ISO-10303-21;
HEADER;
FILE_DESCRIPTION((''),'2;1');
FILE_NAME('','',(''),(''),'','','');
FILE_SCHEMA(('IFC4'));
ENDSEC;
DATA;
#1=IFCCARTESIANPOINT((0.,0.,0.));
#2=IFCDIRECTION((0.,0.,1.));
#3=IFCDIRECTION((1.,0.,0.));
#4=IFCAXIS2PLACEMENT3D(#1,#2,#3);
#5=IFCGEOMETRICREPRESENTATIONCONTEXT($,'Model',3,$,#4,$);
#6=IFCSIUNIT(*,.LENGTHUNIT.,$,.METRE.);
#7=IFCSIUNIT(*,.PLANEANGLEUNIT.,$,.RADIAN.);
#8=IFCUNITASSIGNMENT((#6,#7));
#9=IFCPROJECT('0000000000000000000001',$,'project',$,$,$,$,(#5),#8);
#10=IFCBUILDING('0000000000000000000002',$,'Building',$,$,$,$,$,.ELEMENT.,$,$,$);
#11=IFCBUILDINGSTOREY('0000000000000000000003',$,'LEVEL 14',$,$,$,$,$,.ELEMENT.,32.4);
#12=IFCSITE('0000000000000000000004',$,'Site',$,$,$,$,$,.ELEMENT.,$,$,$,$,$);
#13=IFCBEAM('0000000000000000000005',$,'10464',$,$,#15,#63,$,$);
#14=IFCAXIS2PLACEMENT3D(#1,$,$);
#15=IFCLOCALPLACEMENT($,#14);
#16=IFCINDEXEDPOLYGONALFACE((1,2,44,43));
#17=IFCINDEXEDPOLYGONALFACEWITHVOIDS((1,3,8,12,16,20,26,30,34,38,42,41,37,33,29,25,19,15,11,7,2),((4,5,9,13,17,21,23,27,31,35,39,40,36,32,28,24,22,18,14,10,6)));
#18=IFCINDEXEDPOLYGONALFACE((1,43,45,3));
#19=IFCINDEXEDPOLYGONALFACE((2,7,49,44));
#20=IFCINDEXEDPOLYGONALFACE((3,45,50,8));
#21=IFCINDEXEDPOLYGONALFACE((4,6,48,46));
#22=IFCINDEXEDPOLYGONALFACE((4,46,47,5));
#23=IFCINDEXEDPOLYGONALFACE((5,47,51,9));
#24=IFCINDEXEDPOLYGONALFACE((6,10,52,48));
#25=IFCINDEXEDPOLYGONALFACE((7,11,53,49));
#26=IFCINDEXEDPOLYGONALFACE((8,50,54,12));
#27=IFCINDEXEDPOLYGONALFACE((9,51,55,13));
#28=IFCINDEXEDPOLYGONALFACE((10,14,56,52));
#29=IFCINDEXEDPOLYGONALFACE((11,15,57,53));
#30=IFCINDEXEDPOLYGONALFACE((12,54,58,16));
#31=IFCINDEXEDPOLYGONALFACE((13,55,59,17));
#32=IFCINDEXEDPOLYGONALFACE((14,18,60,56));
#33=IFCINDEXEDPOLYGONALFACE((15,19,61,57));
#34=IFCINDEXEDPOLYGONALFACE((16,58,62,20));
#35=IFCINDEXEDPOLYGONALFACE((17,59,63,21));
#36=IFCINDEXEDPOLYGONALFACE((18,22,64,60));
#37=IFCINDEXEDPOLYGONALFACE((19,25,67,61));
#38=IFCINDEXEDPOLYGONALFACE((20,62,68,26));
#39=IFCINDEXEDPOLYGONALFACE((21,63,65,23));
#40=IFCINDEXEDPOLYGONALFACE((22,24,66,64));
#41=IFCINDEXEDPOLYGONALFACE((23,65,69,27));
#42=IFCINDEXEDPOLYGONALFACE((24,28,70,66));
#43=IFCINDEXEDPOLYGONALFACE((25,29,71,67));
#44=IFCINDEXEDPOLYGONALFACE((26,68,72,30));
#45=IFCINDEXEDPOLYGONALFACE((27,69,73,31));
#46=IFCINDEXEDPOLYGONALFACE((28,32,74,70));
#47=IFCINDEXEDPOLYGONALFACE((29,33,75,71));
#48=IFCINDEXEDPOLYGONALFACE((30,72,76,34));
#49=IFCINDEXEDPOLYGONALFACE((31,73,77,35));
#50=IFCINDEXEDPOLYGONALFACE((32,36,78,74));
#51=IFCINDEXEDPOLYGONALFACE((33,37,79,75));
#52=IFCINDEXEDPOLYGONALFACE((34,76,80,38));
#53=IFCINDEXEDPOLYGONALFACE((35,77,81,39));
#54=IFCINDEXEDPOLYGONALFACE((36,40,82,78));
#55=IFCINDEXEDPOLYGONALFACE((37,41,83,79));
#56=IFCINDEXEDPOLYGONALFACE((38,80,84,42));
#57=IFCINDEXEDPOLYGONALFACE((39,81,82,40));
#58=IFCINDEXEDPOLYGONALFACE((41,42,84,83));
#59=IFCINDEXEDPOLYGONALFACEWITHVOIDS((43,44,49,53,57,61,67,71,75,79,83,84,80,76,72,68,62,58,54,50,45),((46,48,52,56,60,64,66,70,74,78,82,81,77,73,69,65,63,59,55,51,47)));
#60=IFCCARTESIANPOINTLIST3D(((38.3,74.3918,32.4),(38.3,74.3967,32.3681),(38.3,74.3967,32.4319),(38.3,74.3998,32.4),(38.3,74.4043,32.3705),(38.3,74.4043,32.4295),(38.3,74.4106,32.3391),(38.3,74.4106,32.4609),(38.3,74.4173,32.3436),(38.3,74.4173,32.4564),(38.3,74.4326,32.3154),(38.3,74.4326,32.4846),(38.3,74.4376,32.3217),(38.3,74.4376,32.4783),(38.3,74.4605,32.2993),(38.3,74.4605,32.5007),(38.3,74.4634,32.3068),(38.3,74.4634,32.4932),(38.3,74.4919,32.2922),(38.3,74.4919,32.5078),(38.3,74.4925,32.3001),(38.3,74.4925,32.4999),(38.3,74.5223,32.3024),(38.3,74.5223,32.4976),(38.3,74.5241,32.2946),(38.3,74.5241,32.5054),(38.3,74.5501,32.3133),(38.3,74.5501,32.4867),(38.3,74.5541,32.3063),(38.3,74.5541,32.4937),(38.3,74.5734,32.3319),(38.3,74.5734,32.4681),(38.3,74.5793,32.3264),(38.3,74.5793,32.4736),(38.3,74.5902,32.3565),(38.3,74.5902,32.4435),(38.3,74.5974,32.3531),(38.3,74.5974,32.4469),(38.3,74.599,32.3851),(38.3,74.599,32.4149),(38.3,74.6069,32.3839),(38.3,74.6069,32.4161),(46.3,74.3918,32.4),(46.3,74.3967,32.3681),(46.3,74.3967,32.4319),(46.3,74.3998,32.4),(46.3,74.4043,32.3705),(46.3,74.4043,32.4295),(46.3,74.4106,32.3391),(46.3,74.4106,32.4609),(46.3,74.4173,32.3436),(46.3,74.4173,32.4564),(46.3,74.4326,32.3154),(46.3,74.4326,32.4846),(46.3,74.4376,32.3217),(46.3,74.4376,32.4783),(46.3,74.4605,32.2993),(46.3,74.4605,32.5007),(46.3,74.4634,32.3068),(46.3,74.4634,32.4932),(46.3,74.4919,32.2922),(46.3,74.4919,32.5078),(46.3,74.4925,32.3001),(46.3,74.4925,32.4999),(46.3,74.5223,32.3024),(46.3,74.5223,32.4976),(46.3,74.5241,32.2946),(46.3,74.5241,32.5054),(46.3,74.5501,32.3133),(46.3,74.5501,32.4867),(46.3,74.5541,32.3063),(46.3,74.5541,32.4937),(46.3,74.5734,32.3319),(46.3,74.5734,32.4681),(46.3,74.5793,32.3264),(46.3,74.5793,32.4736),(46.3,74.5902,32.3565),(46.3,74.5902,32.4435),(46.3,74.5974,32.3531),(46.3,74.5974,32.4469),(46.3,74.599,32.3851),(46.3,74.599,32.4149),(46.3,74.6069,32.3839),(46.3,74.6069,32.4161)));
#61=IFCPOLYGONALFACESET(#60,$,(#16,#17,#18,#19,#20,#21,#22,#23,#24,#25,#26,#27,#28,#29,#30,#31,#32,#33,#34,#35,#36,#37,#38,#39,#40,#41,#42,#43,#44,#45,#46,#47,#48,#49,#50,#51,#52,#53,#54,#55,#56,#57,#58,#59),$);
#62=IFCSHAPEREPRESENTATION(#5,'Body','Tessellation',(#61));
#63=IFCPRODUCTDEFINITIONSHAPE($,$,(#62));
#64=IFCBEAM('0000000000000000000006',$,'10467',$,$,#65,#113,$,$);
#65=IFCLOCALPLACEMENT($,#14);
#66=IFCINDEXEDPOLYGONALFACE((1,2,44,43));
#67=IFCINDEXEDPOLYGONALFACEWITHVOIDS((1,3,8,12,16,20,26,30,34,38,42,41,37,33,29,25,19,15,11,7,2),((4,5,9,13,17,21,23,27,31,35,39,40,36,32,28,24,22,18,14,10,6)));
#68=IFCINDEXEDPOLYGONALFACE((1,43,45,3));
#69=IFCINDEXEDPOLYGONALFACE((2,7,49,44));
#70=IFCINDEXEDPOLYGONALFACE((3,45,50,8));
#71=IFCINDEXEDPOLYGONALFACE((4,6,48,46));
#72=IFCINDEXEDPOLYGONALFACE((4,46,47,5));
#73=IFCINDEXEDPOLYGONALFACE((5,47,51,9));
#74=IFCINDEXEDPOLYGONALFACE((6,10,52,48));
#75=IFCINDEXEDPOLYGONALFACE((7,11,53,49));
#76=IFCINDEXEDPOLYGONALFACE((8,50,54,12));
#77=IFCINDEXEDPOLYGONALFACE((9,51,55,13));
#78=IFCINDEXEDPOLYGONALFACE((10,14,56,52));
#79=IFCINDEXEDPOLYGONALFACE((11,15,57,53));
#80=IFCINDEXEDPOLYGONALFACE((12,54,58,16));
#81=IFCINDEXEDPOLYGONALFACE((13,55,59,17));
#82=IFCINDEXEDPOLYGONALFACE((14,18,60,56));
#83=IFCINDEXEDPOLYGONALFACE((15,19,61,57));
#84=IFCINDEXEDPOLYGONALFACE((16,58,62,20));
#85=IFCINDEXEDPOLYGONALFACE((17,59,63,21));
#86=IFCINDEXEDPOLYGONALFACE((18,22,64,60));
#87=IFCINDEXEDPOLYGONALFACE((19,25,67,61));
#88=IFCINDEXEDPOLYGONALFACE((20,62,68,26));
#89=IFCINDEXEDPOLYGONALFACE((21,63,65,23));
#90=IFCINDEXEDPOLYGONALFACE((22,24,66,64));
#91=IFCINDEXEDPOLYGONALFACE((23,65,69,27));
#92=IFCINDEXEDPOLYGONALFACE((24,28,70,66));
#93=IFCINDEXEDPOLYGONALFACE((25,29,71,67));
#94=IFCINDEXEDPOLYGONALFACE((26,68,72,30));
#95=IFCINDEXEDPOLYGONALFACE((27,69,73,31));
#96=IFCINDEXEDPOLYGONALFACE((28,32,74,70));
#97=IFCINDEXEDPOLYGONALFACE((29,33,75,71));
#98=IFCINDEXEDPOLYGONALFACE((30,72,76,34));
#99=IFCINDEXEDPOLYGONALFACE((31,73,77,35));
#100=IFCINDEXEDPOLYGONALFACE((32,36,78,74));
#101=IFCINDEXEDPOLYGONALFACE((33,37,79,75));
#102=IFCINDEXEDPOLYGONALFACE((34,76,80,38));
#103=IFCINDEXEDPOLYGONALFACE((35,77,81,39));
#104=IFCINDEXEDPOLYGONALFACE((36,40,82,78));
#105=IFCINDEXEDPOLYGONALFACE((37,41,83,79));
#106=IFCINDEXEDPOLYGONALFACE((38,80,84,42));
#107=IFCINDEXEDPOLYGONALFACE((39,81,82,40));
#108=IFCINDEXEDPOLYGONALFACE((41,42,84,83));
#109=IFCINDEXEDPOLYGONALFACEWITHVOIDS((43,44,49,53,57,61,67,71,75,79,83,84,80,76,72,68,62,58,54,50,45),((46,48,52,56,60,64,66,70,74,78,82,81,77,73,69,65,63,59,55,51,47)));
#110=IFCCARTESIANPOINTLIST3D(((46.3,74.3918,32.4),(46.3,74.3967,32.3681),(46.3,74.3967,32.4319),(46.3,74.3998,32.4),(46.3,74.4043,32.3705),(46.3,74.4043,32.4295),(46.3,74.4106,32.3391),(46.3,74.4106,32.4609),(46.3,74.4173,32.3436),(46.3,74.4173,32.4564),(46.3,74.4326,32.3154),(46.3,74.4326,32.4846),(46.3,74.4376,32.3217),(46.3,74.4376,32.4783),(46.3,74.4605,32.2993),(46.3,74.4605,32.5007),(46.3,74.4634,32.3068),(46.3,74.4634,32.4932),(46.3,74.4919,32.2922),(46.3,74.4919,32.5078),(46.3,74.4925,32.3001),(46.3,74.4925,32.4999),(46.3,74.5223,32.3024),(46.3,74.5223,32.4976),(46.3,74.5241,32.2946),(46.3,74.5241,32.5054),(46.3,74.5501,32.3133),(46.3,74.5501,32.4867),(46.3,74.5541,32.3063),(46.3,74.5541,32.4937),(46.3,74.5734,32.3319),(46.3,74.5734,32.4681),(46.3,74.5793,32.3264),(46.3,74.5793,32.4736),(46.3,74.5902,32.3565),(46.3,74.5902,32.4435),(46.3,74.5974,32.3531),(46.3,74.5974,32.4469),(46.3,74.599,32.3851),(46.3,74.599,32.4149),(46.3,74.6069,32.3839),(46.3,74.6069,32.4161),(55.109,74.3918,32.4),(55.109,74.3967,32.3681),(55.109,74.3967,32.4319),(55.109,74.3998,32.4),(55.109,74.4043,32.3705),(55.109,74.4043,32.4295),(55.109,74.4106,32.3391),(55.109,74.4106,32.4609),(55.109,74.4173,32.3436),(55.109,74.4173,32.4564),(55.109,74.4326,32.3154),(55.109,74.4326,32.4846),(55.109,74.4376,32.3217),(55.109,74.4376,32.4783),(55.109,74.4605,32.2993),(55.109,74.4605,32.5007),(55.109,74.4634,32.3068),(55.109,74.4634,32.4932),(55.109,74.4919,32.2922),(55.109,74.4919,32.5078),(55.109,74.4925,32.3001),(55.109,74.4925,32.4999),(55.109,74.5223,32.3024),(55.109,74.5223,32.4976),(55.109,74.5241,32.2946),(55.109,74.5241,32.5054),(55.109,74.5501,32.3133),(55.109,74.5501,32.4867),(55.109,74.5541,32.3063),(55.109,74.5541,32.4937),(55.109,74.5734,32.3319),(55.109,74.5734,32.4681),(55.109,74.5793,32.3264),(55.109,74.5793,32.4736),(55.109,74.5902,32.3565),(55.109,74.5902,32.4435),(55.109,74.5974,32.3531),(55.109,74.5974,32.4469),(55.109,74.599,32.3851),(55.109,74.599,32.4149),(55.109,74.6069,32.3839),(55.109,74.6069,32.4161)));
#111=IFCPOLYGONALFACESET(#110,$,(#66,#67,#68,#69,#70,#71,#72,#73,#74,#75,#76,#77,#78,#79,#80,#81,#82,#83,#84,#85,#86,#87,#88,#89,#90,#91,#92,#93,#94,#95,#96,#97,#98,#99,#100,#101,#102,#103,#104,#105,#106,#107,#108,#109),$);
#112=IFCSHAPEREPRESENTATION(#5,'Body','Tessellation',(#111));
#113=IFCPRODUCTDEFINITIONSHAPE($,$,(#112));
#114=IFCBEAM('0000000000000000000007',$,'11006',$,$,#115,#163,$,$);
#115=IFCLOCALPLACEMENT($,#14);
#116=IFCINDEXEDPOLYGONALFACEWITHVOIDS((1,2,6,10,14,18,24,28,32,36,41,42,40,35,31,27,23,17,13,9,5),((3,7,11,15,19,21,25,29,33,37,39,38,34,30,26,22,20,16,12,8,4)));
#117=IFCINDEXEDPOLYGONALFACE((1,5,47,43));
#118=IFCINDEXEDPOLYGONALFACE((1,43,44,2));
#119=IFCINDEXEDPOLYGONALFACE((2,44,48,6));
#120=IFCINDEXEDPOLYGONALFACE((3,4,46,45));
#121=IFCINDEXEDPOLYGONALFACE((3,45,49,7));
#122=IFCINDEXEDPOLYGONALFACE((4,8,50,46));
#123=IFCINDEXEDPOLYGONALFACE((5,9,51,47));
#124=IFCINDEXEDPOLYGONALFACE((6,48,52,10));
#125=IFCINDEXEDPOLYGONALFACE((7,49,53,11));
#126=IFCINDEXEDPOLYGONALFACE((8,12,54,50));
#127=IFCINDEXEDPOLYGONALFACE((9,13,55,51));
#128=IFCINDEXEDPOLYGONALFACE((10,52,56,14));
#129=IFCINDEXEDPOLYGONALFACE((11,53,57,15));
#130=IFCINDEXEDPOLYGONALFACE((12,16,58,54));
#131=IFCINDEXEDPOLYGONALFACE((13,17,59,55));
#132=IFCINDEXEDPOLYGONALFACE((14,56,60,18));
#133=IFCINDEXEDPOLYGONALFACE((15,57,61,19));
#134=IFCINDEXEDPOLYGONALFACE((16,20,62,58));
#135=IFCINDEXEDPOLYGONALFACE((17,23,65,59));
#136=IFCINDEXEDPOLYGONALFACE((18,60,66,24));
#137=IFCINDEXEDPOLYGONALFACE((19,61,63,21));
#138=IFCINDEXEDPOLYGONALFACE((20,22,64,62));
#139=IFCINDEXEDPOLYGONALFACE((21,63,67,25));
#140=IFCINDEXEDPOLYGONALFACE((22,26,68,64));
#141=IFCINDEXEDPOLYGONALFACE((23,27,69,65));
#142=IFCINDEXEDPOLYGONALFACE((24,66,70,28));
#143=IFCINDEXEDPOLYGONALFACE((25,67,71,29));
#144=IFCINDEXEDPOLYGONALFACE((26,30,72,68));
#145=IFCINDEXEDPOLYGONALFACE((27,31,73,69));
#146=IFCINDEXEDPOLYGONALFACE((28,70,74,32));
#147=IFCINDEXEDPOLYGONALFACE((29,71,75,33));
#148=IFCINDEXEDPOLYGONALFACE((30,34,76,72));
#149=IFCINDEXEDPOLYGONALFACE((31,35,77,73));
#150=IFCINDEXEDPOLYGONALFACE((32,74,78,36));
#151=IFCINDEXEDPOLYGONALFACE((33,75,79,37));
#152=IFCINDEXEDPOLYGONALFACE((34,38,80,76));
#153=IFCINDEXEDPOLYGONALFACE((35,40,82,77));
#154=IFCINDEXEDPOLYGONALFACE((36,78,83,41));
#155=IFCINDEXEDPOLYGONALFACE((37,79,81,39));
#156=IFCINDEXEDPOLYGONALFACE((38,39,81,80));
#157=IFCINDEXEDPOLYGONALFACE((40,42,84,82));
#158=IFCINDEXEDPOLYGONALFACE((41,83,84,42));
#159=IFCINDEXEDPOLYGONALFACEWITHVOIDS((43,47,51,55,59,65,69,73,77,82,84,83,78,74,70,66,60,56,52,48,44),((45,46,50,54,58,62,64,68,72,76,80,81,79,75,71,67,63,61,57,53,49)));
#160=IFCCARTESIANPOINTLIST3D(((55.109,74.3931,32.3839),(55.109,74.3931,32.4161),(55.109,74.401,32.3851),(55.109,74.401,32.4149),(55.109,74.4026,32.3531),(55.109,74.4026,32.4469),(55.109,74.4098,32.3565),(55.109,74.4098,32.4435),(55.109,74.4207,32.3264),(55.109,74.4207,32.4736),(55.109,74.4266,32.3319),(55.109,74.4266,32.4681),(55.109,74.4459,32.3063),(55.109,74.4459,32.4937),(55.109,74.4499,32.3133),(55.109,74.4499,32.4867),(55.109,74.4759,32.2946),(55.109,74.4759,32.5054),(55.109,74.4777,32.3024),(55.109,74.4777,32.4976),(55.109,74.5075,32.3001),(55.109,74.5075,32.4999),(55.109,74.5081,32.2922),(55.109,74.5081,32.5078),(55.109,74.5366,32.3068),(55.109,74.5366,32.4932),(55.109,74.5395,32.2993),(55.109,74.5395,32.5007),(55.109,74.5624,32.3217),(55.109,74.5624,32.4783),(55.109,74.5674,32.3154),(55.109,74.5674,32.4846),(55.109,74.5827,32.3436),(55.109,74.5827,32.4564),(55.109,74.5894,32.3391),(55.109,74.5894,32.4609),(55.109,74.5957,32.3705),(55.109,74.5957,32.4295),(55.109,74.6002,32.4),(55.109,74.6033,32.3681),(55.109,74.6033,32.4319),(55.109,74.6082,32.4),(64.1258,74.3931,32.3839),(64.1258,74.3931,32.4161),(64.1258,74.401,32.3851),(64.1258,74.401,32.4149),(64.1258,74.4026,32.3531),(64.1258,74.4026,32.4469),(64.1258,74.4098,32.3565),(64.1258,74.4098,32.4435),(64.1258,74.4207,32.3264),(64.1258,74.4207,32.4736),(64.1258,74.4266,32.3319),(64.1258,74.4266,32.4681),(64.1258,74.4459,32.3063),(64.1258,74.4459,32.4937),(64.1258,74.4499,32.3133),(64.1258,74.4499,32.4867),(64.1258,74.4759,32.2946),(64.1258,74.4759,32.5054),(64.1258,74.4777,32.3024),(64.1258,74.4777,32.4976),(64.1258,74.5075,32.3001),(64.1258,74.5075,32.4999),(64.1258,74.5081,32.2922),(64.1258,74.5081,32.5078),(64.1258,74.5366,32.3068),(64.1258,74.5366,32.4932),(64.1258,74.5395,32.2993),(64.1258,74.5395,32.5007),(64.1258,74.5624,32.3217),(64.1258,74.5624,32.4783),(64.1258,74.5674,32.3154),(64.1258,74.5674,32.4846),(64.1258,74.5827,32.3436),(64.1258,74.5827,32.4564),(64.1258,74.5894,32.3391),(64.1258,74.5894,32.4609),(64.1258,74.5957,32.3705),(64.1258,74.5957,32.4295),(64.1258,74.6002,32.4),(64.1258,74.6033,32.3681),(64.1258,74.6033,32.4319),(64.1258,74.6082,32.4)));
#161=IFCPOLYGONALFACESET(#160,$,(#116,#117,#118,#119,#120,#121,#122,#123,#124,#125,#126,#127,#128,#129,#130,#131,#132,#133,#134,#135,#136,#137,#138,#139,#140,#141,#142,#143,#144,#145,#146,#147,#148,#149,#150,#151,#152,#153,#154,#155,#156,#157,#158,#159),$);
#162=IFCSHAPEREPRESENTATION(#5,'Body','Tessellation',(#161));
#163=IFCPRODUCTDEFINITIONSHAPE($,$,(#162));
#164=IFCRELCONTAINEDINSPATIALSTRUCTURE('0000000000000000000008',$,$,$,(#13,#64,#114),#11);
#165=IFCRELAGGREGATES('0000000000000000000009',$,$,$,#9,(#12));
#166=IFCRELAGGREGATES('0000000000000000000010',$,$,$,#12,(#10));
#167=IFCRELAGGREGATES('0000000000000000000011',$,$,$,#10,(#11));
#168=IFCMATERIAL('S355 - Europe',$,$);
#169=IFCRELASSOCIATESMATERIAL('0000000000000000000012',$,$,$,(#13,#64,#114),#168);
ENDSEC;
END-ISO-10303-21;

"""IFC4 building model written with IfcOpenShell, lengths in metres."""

from ifc_helpers import new_model, si_unit, frame, origin_with_axes, origin_2d_with_axis, place, context, project, spatial, hollow_circle, extrude, material, material_profile, profile_set, profile_usage, element, save


model = new_model("IFC4")

# Units and contexts
model_context = context("Model", 3, world=origin_with_axes())
ifc_project = project(units=[si_unit("LENGTHUNIT", "METRE"), si_unit("PLANEANGLEUNIT", "RADIAN")], contexts=[model_context])

# Site, building, storey
site = spatial("IfcSite", under=ifc_project, Name="Site", CompositionType="ELEMENT")
building = spatial("IfcBuilding", under=site, Name="Building", CompositionType="ELEMENT")
storey = spatial("IfcBuildingStorey", under=building, Name="LEVEL 14", CompositionType="ELEMENT", Elevation=32.4)

# Shared definitions
ifc_material = material(Name="S355 - Europe")

# Beams
ifc_material_profile_1 = material_profile(ifc_material, hollow_circle(Radius=0.1081, WallThickness=0.008, at=origin_2d_with_axis()))
ifc_profile_set_1 = profile_set([ifc_material_profile_1])
ifc_profile_usage_1 = profile_usage(ifc_profile_set_1, cardinal=10)
beam_1_placement = place(None, frame((46.3, 74.5, 32.4), z_axis=(-1.0, 0.0, 0.0), x_axis=(0.0, -1.0, 0.0)))
element("IfcBeam", 1, at=beam_1_placement, inside=storey, material=ifc_profile_usage_1, Name="10464", context=model_context, shape_type="SweptSolid", body=[
    extrude(hollow_circle(Radius=0.1081, WallThickness=0.008, at=origin_2d_with_axis()), origin_with_axes(), (0.0, 0.0, 1.0), 8.0),
])
ifc_material_profile_2 = material_profile(ifc_material, hollow_circle(Radius=0.1081, WallThickness=0.008, at=origin_2d_with_axis()))
ifc_profile_set_2 = profile_set([ifc_material_profile_2])
ifc_profile_usage_2 = profile_usage(ifc_profile_set_2, cardinal=10)
beam_2_placement = place(None, frame((55.109, 74.5, 32.4), z_axis=(-1.0, 0.0, 0.0), x_axis=(0.0, -1.0, 0.0)))
element("IfcBeam", 2, at=beam_2_placement, inside=storey, material=ifc_profile_usage_2, Name="10467", context=model_context, shape_type="SweptSolid", body=[
    extrude(hollow_circle(Radius=0.1081, WallThickness=0.008, at=origin_2d_with_axis()), origin_with_axes(), (0.0, 0.0, 1.0), 8.809),
])
ifc_material_profile_3 = material_profile(ifc_material, hollow_circle(Radius=0.1081, WallThickness=0.008, at=origin_2d_with_axis()))
ifc_profile_set_3 = profile_set([ifc_material_profile_3])
ifc_profile_usage_3 = profile_usage(ifc_profile_set_3, cardinal=10)
beam_3_placement = place(None, frame((55.109, 74.5, 32.4), z_axis=(1.0, 0.0, 0.0), x_axis=(0.0, 1.0, 0.0)))
element("IfcBeam", 3, at=beam_3_placement, inside=storey, material=ifc_profile_usage_3, Name="11006", context=model_context, shape_type="SweptSolid", body=[
    extrude(hollow_circle(Radius=0.1081, WallThickness=0.008, at=origin_2d_with_axis()), origin_with_axes(), (0.0, 0.0, 1.0), 9.0168),
])

save(model, "model.ifc")
